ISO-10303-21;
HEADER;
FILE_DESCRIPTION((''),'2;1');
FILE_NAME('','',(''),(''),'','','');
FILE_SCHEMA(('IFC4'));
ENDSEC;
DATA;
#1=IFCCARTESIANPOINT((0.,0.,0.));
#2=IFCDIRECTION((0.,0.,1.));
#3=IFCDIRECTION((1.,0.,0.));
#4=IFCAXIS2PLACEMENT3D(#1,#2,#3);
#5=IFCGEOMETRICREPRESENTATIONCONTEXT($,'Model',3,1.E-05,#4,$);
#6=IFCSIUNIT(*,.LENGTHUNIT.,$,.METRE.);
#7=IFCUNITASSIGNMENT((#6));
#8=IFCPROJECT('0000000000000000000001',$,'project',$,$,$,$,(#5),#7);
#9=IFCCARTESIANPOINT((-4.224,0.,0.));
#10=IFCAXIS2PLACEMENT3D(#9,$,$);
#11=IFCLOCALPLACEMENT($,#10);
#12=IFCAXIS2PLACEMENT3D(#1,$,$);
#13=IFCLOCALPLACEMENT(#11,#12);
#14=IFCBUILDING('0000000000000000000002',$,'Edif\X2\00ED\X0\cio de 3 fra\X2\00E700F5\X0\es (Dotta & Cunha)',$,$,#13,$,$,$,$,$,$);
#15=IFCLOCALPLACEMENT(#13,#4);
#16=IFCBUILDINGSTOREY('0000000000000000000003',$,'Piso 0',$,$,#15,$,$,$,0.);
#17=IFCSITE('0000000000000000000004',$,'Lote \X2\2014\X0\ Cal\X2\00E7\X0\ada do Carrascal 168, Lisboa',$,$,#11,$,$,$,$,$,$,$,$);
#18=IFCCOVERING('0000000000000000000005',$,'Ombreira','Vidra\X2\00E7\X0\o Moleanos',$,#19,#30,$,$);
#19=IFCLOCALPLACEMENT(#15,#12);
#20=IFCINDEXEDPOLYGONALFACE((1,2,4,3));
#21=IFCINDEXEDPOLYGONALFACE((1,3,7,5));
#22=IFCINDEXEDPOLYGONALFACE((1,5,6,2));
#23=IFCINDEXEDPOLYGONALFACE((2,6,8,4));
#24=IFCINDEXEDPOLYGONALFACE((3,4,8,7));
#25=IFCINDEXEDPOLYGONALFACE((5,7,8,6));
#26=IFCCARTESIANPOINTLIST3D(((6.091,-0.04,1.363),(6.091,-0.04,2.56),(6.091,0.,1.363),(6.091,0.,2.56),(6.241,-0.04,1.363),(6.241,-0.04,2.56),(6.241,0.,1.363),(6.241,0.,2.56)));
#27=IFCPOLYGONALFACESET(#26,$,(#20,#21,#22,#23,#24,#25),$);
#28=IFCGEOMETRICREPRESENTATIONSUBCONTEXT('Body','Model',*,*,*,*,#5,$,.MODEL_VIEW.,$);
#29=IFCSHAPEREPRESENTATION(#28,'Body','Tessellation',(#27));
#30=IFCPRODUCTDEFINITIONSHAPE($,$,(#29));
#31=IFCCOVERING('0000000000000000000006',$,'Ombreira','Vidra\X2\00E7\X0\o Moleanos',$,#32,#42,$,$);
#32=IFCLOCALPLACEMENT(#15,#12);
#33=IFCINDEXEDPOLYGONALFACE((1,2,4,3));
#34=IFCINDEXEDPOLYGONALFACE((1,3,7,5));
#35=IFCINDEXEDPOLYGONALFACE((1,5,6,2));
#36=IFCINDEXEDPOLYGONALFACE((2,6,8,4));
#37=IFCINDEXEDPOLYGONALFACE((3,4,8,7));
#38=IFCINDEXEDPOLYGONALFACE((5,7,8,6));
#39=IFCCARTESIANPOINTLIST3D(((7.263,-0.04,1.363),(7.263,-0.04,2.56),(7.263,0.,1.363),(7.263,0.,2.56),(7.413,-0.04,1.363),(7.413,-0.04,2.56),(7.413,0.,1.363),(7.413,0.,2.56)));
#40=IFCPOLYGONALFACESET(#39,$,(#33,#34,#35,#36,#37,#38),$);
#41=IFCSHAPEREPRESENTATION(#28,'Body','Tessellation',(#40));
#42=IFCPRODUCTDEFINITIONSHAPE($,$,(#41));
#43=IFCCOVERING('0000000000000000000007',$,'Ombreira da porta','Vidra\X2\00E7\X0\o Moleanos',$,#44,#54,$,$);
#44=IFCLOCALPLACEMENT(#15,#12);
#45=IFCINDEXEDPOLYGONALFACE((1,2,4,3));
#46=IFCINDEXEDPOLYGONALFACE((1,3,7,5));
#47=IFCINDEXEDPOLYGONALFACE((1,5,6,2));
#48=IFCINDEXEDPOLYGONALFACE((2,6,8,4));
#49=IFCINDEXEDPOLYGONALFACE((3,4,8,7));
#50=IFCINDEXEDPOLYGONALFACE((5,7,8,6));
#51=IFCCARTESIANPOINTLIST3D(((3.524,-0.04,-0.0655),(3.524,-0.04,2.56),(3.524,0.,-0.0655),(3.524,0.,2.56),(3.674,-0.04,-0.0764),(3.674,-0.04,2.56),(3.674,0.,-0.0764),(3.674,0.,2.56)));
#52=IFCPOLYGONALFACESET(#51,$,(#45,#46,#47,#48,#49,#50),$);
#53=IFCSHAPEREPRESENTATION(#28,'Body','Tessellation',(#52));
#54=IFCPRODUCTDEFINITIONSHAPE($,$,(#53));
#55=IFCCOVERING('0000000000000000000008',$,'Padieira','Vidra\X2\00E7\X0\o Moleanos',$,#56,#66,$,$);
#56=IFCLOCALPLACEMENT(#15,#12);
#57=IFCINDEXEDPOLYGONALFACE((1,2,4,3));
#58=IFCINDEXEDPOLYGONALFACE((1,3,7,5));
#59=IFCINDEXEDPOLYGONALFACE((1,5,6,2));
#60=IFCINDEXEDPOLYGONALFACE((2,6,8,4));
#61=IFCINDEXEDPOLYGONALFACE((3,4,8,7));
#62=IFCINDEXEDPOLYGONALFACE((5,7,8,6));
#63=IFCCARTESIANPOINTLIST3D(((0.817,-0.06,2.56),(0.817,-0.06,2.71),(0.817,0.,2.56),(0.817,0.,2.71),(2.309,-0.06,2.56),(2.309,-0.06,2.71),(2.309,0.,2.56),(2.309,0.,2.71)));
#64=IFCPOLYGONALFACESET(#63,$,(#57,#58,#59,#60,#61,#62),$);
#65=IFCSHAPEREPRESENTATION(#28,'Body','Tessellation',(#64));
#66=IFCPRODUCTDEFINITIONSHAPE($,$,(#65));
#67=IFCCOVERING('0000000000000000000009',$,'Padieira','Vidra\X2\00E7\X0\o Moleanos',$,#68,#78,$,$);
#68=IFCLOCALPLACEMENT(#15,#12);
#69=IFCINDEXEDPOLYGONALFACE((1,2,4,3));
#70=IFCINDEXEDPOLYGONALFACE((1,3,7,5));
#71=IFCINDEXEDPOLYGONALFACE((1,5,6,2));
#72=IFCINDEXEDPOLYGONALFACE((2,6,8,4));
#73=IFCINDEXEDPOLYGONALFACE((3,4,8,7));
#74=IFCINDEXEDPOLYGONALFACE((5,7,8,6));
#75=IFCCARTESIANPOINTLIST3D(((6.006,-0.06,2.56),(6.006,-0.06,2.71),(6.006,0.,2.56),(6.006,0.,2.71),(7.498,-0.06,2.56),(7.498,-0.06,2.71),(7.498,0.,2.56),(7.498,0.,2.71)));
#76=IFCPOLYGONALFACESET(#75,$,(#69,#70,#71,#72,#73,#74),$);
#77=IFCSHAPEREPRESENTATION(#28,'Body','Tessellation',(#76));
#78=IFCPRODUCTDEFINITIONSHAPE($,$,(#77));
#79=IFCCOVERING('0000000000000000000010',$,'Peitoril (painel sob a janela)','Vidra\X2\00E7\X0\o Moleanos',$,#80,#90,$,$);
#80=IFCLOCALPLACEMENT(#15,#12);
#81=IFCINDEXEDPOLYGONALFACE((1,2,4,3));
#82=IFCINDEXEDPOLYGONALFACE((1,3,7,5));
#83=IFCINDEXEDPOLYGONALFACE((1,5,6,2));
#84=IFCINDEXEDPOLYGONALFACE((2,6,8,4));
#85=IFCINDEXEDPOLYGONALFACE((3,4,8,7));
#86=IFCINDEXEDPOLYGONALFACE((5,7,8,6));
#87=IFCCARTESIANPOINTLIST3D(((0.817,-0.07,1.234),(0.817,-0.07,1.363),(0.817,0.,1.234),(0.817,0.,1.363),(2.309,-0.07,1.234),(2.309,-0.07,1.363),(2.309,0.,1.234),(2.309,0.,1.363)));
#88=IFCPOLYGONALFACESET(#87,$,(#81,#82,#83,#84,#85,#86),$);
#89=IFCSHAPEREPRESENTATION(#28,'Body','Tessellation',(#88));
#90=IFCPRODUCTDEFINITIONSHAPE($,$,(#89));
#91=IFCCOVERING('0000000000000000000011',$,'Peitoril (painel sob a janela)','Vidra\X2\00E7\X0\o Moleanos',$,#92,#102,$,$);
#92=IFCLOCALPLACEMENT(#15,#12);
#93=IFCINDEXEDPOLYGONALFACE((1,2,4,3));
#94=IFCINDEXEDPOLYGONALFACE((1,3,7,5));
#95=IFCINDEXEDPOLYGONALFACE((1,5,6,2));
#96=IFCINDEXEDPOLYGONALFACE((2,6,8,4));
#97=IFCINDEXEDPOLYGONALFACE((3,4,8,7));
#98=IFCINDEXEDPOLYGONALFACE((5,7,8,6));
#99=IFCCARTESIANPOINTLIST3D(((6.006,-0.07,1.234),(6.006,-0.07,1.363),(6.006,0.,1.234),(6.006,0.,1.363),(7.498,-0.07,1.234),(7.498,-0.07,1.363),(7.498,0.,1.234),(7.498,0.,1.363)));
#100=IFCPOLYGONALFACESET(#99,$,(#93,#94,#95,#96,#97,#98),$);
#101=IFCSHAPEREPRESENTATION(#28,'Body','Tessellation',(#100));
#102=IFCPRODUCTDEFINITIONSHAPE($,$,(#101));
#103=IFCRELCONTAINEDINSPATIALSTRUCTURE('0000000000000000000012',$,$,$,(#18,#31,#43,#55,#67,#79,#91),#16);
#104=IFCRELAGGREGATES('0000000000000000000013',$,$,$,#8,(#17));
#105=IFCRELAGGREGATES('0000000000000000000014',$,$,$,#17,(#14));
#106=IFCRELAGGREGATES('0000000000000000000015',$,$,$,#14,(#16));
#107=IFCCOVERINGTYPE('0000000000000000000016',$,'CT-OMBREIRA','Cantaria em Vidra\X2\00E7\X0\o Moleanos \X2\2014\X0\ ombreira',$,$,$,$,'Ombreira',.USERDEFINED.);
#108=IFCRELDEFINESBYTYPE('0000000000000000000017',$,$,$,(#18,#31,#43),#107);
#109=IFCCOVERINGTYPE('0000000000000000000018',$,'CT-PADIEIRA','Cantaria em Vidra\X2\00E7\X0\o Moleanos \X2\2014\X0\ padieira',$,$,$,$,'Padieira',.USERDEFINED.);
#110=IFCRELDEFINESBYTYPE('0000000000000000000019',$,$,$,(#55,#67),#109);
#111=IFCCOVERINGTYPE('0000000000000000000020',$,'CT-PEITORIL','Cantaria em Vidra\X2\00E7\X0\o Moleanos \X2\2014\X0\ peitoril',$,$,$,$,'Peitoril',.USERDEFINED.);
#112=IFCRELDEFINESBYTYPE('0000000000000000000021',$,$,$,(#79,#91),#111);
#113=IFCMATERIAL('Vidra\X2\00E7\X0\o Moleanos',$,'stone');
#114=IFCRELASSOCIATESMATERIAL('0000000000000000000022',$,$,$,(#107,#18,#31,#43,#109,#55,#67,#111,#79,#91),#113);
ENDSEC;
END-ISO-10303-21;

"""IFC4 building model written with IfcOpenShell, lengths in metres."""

from ifc_helpers import new_model, si_unit, frame, origin, origin_with_axes, place, context, subcontext, project, spatial, line, indexed_curve, outline, extrude, material, type_object, element, save


model = new_model("IFC4")

# Units and contexts
model_context = context("Model", 3, precision=1e-05, world=origin_with_axes())
body_context = subcontext(model_context, "Body", "Model", "MODEL_VIEW")
ifc_project = project(units=[si_unit("LENGTHUNIT", "METRE")], contexts=[model_context])

# Site, building, storey
site_placement = place(None, frame((-4.224, 0.0, 0.0)))
site = spatial("IfcSite", under=ifc_project, at=site_placement, Name="Lote — Calçada do Carrascal 168, Lisboa")
building_placement = place(site_placement, origin())
building = spatial("IfcBuilding", under=site, at=building_placement, Name="Edifício de 3 frações (Dotta & Cunha)")
storey_placement = place(building_placement, origin_with_axes())
storey = spatial("IfcBuildingStorey", under=building, at=storey_placement, Name="Piso 0", Elevation=0.0)

# Coverings
ifc_material = material(Name="Vidraço Moleanos", Category="stone")
covering_type_1 = type_object("IfcCoveringType", Name="CT-OMBREIRA", Description="Cantaria em Vidraço Moleanos — ombreira", ElementType="Ombreira", PredefinedType="USERDEFINED", material=ifc_material)
covering_1_placement = place(storey_placement, frame((0.0, 0.0, 0.0), z_axis=(0.0, -1.0, 0.0), x_axis=(1.0, 0.0, 0.0)))
element("IfcCovering", 1, at=covering_1_placement, inside=storey, type_object=covering_type_1, material=ifc_material, Name="Ombreira", Description="Vidraço Moleanos", context=body_context, shape_type="SweptSolid", body=[
    extrude(outline(indexed_curve([(6.241, 1.363), (6.241, 2.56), (6.091, 2.56), (6.091, 1.363)], segments=[line(1, 2, 3, 4, 1)])), origin_with_axes(), (0.0, 0.0, 1.0), 0.04),
])
covering_2_placement = place(storey_placement, frame((0.0, 0.0, 0.0), z_axis=(0.0, -1.0, 0.0), x_axis=(1.0, 0.0, 0.0)))
element("IfcCovering", 2, at=covering_2_placement, inside=storey, type_object=covering_type_1, material=ifc_material, Name="Ombreira", Description="Vidraço Moleanos", context=body_context, shape_type="SweptSolid", body=[
    extrude(outline(indexed_curve([(7.413, 1.363), (7.413, 2.56), (7.263, 2.56), (7.263, 1.363)], segments=[line(1, 2, 3, 4, 1)])), origin_with_axes(), (0.0, 0.0, 1.0), 0.04),
])
covering_3_placement = place(storey_placement, frame((0.0, 0.0, 0.0), z_axis=(0.0, -1.0, 0.0), x_axis=(1.0, 0.0, 0.0)))
element("IfcCovering", 3, at=covering_3_placement, inside=storey, type_object=covering_type_1, material=ifc_material, Name="Ombreira da porta", Description="Vidraço Moleanos", context=body_context, shape_type="SweptSolid", body=[
    extrude(outline(indexed_curve([(3.524, -0.0655), (3.674, -0.0764), (3.674, 2.56), (3.524, 2.56)], segments=[line(1, 2, 3, 4, 1)])), origin_with_axes(), (0.0, 0.0, 1.0), 0.04),
])
covering_type_2 = type_object("IfcCoveringType", Name="CT-PADIEIRA", Description="Cantaria em Vidraço Moleanos — padieira", ElementType="Padieira", PredefinedType="USERDEFINED", material=ifc_material)
covering_4_placement = place(storey_placement, frame((0.0, 0.0, 0.0), z_axis=(0.0, -1.0, 0.0), x_axis=(1.0, 0.0, 0.0)))
element("IfcCovering", 4, at=covering_4_placement, inside=storey, type_object=covering_type_2, material=ifc_material, Name="Padieira", Description="Vidraço Moleanos", context=body_context, shape_type="SweptSolid", body=[
    extrude(outline(indexed_curve([(2.309, 2.56), (2.309, 2.71), (0.817, 2.71), (0.817, 2.56)], segments=[line(1, 2, 3, 4, 1)])), origin_with_axes(), (0.0, 0.0, 1.0), 0.06),
])
covering_5_placement = place(storey_placement, frame((0.0, 0.0, 0.0), z_axis=(0.0, -1.0, 0.0), x_axis=(1.0, 0.0, 0.0)))
element("IfcCovering", 5, at=covering_5_placement, inside=storey, type_object=covering_type_2, material=ifc_material, Name="Padieira", Description="Vidraço Moleanos", context=body_context, shape_type="SweptSolid", body=[
    extrude(outline(indexed_curve([(7.498, 2.56), (7.498, 2.71), (6.006, 2.71), (6.006, 2.56)], segments=[line(1, 2, 3, 4, 1)])), origin_with_axes(), (0.0, 0.0, 1.0), 0.06),
])
covering_type_3 = type_object("IfcCoveringType", Name="CT-PEITORIL", Description="Cantaria em Vidraço Moleanos — peitoril", ElementType="Peitoril", PredefinedType="USERDEFINED", material=ifc_material)
covering_6_placement = place(storey_placement, frame((0.0, 0.0, 0.0), z_axis=(0.0, -1.0, 0.0), x_axis=(1.0, 0.0, 0.0)))
element("IfcCovering", 6, at=covering_6_placement, inside=storey, type_object=covering_type_3, material=ifc_material, Name="Peitoril (painel sob a janela)", Description="Vidraço Moleanos", context=body_context, shape_type="SweptSolid", body=[
    extrude(outline(indexed_curve([(2.309, 1.234), (2.309, 1.363), (0.817, 1.363), (0.817, 1.234)], segments=[line(1, 2, 3, 4, 1)])), origin_with_axes(), (0.0, 0.0, 1.0), 0.07),
])
covering_7_placement = place(storey_placement, frame((0.0, 0.0, 0.0), z_axis=(0.0, -1.0, 0.0), x_axis=(1.0, 0.0, 0.0)))
element("IfcCovering", 7, at=covering_7_placement, inside=storey, type_object=covering_type_3, material=ifc_material, Name="Peitoril (painel sob a janela)", Description="Vidraço Moleanos", context=body_context, shape_type="SweptSolid", body=[
    extrude(outline(indexed_curve([(7.498, 1.234), (7.498, 1.363), (6.006, 1.363), (6.006, 1.234)], segments=[line(1, 2, 3, 4, 1)])), origin_with_axes(), (0.0, 0.0, 1.0), 0.07),
])

save(model, "model.ifc")
